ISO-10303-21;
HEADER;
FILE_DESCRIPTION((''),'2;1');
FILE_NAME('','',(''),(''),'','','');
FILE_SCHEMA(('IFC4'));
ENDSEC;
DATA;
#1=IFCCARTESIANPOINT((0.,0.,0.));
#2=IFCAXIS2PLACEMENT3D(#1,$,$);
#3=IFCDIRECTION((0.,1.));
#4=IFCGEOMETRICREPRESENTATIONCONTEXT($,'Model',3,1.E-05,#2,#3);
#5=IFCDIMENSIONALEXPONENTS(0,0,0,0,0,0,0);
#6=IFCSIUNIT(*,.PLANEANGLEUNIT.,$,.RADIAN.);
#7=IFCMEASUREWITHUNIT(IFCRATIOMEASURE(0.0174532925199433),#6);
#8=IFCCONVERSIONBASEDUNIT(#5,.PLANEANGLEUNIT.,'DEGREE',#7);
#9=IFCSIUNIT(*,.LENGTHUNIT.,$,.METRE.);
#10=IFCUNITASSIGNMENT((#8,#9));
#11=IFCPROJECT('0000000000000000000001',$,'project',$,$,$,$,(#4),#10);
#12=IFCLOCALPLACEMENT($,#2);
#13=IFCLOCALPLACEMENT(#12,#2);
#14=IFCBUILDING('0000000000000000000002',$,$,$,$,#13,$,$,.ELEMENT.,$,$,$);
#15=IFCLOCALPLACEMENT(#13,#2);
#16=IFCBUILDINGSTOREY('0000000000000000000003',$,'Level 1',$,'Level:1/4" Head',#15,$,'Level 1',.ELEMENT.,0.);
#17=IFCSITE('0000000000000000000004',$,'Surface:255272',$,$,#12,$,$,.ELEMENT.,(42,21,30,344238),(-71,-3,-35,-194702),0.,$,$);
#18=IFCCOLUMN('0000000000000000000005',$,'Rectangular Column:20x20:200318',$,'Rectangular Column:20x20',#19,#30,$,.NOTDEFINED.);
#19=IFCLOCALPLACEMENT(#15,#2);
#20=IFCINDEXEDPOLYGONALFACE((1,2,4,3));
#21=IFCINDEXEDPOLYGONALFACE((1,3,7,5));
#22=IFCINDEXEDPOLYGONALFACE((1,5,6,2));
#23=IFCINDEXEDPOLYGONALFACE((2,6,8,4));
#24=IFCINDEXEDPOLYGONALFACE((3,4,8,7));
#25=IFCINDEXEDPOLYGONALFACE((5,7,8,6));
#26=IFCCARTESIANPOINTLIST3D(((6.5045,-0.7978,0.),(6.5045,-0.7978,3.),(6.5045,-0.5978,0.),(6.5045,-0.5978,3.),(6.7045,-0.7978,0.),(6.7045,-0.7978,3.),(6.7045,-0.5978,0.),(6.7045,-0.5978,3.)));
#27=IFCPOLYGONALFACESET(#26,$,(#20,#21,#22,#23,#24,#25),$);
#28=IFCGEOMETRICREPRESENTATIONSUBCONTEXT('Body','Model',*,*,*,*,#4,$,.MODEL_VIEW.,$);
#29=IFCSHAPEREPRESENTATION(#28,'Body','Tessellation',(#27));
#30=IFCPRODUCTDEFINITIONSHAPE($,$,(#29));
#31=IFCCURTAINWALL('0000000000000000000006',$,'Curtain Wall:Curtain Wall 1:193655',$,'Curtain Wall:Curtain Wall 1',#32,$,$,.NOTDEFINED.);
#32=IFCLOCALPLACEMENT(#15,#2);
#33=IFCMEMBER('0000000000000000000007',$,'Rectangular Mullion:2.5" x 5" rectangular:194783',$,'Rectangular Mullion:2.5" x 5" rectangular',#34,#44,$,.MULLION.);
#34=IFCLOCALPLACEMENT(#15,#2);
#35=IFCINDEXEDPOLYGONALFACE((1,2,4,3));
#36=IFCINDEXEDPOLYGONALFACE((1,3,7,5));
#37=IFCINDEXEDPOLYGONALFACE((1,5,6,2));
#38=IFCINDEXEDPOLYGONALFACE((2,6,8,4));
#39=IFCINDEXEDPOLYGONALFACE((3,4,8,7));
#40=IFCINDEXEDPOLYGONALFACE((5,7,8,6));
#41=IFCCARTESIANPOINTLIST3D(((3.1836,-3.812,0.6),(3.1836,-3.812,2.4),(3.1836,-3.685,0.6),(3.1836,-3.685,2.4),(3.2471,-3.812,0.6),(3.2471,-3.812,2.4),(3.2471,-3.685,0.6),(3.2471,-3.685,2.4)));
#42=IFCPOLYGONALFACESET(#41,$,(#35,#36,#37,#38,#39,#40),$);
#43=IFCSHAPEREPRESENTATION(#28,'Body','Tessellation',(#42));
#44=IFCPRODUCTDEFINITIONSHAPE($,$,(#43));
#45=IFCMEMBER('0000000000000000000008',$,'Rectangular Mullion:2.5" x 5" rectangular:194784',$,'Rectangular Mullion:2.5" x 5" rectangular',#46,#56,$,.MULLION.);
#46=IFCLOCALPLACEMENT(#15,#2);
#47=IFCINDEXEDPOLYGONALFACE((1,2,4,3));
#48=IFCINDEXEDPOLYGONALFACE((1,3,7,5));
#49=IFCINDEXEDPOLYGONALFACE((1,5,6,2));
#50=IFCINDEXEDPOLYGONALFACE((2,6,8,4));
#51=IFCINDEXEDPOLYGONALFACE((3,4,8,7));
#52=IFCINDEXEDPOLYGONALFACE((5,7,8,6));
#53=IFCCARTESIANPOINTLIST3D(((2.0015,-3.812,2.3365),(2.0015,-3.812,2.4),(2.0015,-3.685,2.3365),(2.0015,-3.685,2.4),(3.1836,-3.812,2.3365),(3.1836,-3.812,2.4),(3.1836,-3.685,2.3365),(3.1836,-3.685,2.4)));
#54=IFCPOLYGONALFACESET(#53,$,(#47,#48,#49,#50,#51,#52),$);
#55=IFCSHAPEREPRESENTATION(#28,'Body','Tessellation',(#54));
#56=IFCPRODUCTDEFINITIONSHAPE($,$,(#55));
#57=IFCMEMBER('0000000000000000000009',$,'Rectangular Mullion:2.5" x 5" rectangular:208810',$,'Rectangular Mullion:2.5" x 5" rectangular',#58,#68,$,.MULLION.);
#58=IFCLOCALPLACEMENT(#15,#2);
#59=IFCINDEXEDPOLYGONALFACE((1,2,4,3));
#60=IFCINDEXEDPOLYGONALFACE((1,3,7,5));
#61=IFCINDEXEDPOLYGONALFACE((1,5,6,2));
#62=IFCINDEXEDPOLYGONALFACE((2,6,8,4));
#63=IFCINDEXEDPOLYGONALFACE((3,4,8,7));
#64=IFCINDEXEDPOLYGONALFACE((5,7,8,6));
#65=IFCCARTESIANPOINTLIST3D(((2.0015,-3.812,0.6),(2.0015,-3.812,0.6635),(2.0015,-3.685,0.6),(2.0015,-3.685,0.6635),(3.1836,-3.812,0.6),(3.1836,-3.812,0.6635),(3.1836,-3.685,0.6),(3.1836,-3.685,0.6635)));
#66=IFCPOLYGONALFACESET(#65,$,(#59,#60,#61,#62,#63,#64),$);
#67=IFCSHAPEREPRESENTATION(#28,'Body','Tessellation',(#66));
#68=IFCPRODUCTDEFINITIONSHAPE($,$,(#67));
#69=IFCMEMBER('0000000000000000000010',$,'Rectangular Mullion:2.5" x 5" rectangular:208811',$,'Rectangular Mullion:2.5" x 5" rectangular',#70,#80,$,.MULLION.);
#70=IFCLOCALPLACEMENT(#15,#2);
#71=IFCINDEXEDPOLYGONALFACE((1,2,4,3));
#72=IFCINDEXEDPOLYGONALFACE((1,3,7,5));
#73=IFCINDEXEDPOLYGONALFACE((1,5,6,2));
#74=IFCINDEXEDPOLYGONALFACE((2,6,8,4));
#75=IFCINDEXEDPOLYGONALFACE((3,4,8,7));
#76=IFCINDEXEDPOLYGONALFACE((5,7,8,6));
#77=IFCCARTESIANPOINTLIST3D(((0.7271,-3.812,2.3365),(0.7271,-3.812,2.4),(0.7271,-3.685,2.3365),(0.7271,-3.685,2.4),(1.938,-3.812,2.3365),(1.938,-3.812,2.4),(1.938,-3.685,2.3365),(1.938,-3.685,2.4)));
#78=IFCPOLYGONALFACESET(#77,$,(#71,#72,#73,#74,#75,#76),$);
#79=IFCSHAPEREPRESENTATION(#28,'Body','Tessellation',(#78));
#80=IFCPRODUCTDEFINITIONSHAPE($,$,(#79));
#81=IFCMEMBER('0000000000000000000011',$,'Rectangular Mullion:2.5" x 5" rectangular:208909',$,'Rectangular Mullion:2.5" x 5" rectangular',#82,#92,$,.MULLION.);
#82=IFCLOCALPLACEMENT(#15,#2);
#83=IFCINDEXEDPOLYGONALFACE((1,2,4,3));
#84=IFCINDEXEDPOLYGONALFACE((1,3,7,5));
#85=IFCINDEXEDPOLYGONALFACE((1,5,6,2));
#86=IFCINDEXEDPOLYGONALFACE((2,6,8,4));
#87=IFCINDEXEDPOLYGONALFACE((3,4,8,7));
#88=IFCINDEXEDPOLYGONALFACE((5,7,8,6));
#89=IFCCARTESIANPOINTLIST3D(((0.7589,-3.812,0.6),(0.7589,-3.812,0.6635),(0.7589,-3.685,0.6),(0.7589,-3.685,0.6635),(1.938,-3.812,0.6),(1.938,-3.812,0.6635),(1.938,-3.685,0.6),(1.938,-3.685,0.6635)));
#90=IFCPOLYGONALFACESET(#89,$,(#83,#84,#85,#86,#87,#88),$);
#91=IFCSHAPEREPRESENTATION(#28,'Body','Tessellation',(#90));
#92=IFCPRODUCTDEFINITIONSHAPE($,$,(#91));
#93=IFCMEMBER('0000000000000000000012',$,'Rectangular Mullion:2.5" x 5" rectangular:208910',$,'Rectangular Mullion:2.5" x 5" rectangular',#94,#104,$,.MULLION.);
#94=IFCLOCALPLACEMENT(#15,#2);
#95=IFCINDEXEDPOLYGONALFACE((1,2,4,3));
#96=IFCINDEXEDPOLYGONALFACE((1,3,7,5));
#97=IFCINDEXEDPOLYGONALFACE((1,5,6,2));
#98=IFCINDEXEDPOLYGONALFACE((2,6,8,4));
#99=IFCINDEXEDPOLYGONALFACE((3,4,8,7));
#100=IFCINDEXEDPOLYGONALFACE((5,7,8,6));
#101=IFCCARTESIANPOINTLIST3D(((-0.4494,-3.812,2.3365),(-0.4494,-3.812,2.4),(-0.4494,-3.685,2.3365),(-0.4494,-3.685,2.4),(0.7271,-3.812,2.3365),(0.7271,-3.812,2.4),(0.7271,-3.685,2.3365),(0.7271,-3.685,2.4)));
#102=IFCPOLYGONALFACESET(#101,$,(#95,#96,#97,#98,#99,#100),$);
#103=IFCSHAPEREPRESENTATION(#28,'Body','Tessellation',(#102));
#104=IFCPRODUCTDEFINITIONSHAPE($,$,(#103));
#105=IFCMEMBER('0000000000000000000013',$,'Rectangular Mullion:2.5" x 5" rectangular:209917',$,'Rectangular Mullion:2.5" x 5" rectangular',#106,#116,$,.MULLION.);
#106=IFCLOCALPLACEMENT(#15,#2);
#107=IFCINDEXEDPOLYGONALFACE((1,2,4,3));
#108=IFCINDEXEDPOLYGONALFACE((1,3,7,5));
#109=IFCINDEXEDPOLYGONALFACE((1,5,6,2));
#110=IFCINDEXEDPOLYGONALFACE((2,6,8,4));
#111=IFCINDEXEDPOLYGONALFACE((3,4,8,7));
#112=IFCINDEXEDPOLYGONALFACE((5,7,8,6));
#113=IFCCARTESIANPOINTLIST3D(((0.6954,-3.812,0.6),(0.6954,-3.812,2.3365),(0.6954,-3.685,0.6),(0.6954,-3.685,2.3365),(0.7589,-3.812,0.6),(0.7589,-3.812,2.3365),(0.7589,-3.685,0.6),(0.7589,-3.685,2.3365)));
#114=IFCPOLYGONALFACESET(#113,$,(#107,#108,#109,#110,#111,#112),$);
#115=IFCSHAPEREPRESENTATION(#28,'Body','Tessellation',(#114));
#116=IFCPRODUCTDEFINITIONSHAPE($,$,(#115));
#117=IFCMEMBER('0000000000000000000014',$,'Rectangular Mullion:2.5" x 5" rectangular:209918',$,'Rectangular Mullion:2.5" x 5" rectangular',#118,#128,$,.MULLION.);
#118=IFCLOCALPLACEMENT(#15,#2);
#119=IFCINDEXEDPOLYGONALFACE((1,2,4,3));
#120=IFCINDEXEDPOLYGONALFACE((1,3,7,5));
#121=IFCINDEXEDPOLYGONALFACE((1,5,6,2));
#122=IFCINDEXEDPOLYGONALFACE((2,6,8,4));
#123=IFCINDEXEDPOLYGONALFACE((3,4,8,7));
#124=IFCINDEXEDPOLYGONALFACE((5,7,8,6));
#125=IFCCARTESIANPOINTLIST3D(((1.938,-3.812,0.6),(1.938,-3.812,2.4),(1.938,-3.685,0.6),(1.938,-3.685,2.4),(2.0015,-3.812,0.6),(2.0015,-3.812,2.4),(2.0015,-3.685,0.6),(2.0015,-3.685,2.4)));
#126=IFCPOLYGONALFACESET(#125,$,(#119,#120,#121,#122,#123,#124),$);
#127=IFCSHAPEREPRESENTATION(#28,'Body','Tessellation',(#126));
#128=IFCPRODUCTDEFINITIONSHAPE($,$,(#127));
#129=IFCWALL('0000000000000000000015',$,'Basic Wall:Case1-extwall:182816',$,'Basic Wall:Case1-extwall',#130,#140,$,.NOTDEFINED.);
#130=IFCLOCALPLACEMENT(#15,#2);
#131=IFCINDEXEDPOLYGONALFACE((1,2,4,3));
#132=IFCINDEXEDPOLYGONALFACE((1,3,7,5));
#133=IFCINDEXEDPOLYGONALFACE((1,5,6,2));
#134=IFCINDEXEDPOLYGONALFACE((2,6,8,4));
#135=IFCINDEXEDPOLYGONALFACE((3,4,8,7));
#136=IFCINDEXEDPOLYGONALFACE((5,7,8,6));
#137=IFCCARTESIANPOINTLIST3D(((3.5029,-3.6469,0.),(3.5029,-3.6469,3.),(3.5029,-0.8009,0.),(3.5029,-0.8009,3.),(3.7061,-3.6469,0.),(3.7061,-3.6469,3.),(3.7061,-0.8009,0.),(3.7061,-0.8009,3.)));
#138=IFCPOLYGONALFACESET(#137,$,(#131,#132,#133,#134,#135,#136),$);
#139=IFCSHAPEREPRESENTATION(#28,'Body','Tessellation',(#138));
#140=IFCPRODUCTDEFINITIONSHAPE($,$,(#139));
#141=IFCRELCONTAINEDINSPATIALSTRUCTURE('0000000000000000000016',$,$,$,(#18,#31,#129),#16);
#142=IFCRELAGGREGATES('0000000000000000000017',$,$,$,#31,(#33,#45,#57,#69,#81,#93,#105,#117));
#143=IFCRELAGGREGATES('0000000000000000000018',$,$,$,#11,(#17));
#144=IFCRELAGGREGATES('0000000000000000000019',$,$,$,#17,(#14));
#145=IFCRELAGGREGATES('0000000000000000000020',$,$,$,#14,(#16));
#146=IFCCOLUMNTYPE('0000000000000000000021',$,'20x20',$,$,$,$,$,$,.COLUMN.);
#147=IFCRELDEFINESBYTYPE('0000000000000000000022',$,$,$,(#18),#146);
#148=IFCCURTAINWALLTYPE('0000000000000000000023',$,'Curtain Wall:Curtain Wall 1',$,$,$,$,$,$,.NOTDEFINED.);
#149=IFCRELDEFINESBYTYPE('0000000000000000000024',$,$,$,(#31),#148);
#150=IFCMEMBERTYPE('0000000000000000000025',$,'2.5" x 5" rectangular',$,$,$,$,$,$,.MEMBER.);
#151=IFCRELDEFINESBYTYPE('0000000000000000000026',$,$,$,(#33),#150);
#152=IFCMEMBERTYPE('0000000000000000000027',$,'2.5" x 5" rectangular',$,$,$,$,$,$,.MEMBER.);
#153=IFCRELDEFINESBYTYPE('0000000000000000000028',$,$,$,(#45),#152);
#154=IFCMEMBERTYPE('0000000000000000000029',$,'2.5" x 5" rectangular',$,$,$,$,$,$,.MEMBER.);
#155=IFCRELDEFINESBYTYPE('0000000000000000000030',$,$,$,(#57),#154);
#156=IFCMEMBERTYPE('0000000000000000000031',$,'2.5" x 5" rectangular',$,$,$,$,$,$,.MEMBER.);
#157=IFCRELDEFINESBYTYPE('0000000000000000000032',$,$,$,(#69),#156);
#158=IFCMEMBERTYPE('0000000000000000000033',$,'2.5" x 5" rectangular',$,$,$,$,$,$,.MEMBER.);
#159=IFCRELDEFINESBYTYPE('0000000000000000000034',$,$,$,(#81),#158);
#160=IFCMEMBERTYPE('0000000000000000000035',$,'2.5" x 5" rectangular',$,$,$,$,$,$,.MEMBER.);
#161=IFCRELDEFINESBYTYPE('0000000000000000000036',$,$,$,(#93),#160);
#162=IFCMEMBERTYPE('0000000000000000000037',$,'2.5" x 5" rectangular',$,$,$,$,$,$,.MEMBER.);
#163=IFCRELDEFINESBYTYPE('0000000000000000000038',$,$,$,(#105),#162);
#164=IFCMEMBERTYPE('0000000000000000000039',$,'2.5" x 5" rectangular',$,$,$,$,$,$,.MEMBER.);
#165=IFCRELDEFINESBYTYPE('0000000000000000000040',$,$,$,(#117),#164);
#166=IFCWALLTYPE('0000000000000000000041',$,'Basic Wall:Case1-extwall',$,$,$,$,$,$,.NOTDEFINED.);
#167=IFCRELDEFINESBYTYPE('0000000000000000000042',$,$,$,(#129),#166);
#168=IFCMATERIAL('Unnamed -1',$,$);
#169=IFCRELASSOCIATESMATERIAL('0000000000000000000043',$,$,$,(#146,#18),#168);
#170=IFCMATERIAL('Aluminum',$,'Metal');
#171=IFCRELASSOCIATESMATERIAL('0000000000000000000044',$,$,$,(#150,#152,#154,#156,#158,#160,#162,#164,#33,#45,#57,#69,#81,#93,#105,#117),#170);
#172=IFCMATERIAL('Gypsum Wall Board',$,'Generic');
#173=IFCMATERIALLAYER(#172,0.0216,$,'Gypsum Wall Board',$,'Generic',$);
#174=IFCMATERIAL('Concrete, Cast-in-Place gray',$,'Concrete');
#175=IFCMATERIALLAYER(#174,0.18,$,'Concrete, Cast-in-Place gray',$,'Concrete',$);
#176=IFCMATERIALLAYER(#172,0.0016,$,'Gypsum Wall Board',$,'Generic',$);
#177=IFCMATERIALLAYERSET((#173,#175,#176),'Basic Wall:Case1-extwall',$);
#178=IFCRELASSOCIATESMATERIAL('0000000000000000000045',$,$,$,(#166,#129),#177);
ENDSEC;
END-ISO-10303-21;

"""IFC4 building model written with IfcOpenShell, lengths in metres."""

from ifc_helpers import new_model, entity, si_unit, converted_unit, direction, frame, frame_2d, origin, origin_2d_with_axis, place, context, subcontext, project, spatial, polyline, rectangle, extrude, clip, bounded_halfspace, source, transform, mapped, material, layer, layer_set, layer_usage, material_profile, profile_set, profile_usage, type_object, type_shapes, element, aggregate, save


model = new_model("IFC4")

# Units and contexts
model_context = context("Model", 3, precision=1e-05, world=origin(), true_north=direction((0.0, 1.0)))
body_context = subcontext(model_context, "Body", "Model", "MODEL_VIEW")
ifc_project = project(units=[converted_unit("PLANEANGLEUNIT", "DEGREE", entity("IfcRatioMeasure", 0.0174532925199433), si_unit("PLANEANGLEUNIT", "RADIAN"), dimensions=[0, 0, 0, 0, 0, 0, 0]), si_unit("LENGTHUNIT", "METRE")], contexts=[model_context])

# Site, building, storey
site_placement = place(None, origin())
site = spatial("IfcSite", under=ifc_project, at=site_placement, Name="Surface:255272", CompositionType="ELEMENT", RefLatitude=(42, 21, 30, 344238), RefLongitude=(-71, -3, -35, -194702), RefElevation=0.0)
building_placement = place(site_placement, origin())
building = spatial("IfcBuilding", under=site, at=building_placement, CompositionType="ELEMENT")
storey_placement = place(building_placement, origin())
storey = spatial("IfcBuildingStorey", under=building, at=storey_placement, Name="Level 1", ObjectType="Level:1/4\" Head", LongName="Level 1", CompositionType="ELEMENT", Elevation=0.0)

# Column
ifc_material_1 = material(Name="Unnamed -1")
ifc_material_profile_1 = material_profile(ifc_material_1, rectangle(XDim=0.2, YDim=0.2, at=origin_2d_with_axis()), Name="20x20")
ifc_profile_set_1 = profile_set([ifc_material_profile_1], Name="20x20")
ifc_profile_usage_1 = profile_usage(ifc_profile_set_1)
column_type = type_object("IfcColumnType", Name="20x20", PredefinedType="COLUMN", material=ifc_profile_set_1)
shared_shape_1 = source(origin(), body_context, "Body", "SweptSolid", [
    extrude(rectangle(XDim=0.2, YDim=0.2, at=origin_2d_with_axis()), frame((0.0, 0.0, 0.0), z_axis=(0.0, 0.0, 1.0), x_axis=(0.0, -1.0, 0.0)), (0.0, 0.0, 1.0), 3.0),
])
type_shapes(column_type, [shared_shape_1])
column_placement = place(storey_placement, frame((6.6045, -0.6978, 0.0)))
element("IfcColumn", 1, at=column_placement, inside=storey, type_object=column_type, material=ifc_profile_usage_1, Name="Rectangular Column:20x20:200318", ObjectType="Rectangular Column:20x20", PredefinedType="NOTDEFINED", context=body_context, shape_type="MappedRepresentation", body=[
    mapped(shared_shape_1, transform((0.0, 0.0, 0.0), scale=1.0)),
])

# Curtain wall, member
curtain_wall_type = type_object("IfcCurtainWallType", Name="Curtain Wall:Curtain Wall 1", PredefinedType="NOTDEFINED")
ifc_material_2 = material(Name="Aluminum", Category="Metal")
ifc_material_profile_2 = material_profile(ifc_material_2, rectangle(XDim=0.127, YDim=0.0635, at=origin_2d_with_axis()), Name="2.5\" x 5\" rectangular")
ifc_profile_set_2 = profile_set([ifc_material_profile_2], Name="2.5\" x 5\" rectangular")
curtain_wall_1_placement = place(storey_placement, origin())
curtain_wall_1 = element("IfcCurtainWall", 2, at=curtain_wall_1_placement, inside=storey, type_object=curtain_wall_type, Name="Curtain Wall:Curtain Wall 1:193655", ObjectType="Curtain Wall:Curtain Wall 1", PredefinedType="NOTDEFINED")
ifc_profile_usage_2 = profile_usage(ifc_profile_set_2)
member_type_1 = type_object("IfcMemberType", Name="2.5\" x 5\" rectangular", PredefinedType="MEMBER", material=ifc_profile_set_2)
shared_shape_2 = source(origin(), body_context, "Body", "SweptSolid", [
    extrude(rectangle(XDim=0.127, YDim=0.0635, at=origin_2d_with_axis()), frame((-0.0318, 0.0, -1.8), z_axis=(0.0, 0.0, 1.0), x_axis=(0.0, -1.0, 0.0)), (0.0, 0.0, 1.0), 1.8),
])
type_shapes(member_type_1, [shared_shape_2])
member_1_placement = place(storey_placement, frame((3.2471, -3.7485, 0.6), z_axis=(0.0, 0.0, -1.0), x_axis=(1.0, -0.000007, 0.0)))
member_1 = element("IfcMember", 3, at=member_1_placement, type_object=member_type_1, material=ifc_profile_usage_2, Name="Rectangular Mullion:2.5\" x 5\" rectangular:194783", ObjectType="Rectangular Mullion:2.5\" x 5\" rectangular", PredefinedType="MULLION", context=body_context, shape_type="MappedRepresentation", body=[
    mapped(shared_shape_2, transform((0.0, 0.0, 0.0), scale=1.0)),
])

# Members
ifc_profile_usage_3 = profile_usage(ifc_profile_set_2)
member_type_2 = type_object("IfcMemberType", Name="2.5\" x 5\" rectangular", PredefinedType="MEMBER", material=ifc_profile_set_2)
shared_shape_3 = source(origin(), body_context, "Body", "SweptSolid", [
    extrude(rectangle(XDim=0.127, YDim=0.0635, at=origin_2d_with_axis()), frame((-0.0318, 0.0, -1.1821), z_axis=(0.0, 0.0, 1.0), x_axis=(0.0, -1.0, 0.0)), (0.0, 0.0, 1.0), 1.1821),
])
type_shapes(member_type_2, [shared_shape_3])
member_2_placement = place(storey_placement, frame((3.1836, -3.7485, 2.4), z_axis=(1.0, -0.000007, 0.0), x_axis=(0.0, 0.0, 1.0)))
member_2 = element("IfcMember", 4, at=member_2_placement, type_object=member_type_2, material=ifc_profile_usage_3, Name="Rectangular Mullion:2.5\" x 5\" rectangular:194784", ObjectType="Rectangular Mullion:2.5\" x 5\" rectangular", PredefinedType="MULLION", context=body_context, shape_type="MappedRepresentation", body=[
    mapped(shared_shape_3, transform((0.0, 0.0, 0.0), scale=1.0)),
])
ifc_profile_usage_4 = profile_usage(ifc_profile_set_2)
member_type_3 = type_object("IfcMemberType", Name="2.5\" x 5\" rectangular", PredefinedType="MEMBER", material=ifc_profile_set_2)
shared_shape_4 = source(origin(), body_context, "Body", "SweptSolid", [
    extrude(rectangle(XDim=0.127, YDim=0.0635, at=origin_2d_with_axis()), frame((-0.0318, 0.0, -1.1821), z_axis=(0.0, 0.0, 1.0), x_axis=(0.0, -1.0, 0.0)), (0.0, 0.0, 1.0), 1.1821),
])
type_shapes(member_type_3, [shared_shape_4])
member_3_placement = place(storey_placement, frame((2.0015, -3.7485, 0.6), z_axis=(-1.0, 0.000007, 0.0), x_axis=(0.0, 0.0, -1.0)))
member_3 = element("IfcMember", 5, at=member_3_placement, type_object=member_type_3, material=ifc_profile_usage_4, Name="Rectangular Mullion:2.5\" x 5\" rectangular:208810", ObjectType="Rectangular Mullion:2.5\" x 5\" rectangular", PredefinedType="MULLION", context=body_context, shape_type="MappedRepresentation", body=[
    mapped(shared_shape_4, transform((0.0, 0.0, 0.0), scale=1.0)),
])
ifc_profile_usage_5 = profile_usage(ifc_profile_set_2)
member_type_4 = type_object("IfcMemberType", Name="2.5\" x 5\" rectangular", PredefinedType="MEMBER", material=ifc_profile_set_2)
shared_shape_5 = source(origin(), body_context, "Body", "SweptSolid", [
    extrude(rectangle(XDim=0.127, YDim=0.0635, at=origin_2d_with_axis()), frame((-0.0318, 0.0, -1.2109), z_axis=(0.0, 0.0, 1.0), x_axis=(0.0, -1.0, 0.0)), (0.0, 0.0, 1.0), 1.2109),
])
type_shapes(member_type_4, [shared_shape_5])
member_4_placement = place(storey_placement, frame((1.938, -3.7485, 2.4), z_axis=(1.0, -0.000007, 0.0), x_axis=(0.0, 0.0, 1.0)))
member_4 = element("IfcMember", 6, at=member_4_placement, type_object=member_type_4, material=ifc_profile_usage_5, Name="Rectangular Mullion:2.5\" x 5\" rectangular:208811", ObjectType="Rectangular Mullion:2.5\" x 5\" rectangular", PredefinedType="MULLION", context=body_context, shape_type="MappedRepresentation", body=[
    mapped(shared_shape_5, transform((0.0, 0.0, 0.0), scale=1.0)),
])
ifc_profile_usage_6 = profile_usage(ifc_profile_set_2)
member_type_5 = type_object("IfcMemberType", Name="2.5\" x 5\" rectangular", PredefinedType="MEMBER", material=ifc_profile_set_2)
shared_shape_6 = source(origin(), body_context, "Body", "SweptSolid", [
    extrude(rectangle(XDim=0.127, YDim=0.0635, at=origin_2d_with_axis()), frame((-0.0318, 0.0, -1.1792), z_axis=(0.0, 0.0, 1.0), x_axis=(0.0, -1.0, 0.0)), (0.0, 0.0, 1.0), 1.1792),
])
type_shapes(member_type_5, [shared_shape_6])
member_5_placement = place(storey_placement, frame((0.7589, -3.7485, 0.6), z_axis=(-1.0, 0.000007, 0.0), x_axis=(0.0, 0.0, -1.0)))
member_5 = element("IfcMember", 7, at=member_5_placement, type_object=member_type_5, material=ifc_profile_usage_6, Name="Rectangular Mullion:2.5\" x 5\" rectangular:208909", ObjectType="Rectangular Mullion:2.5\" x 5\" rectangular", PredefinedType="MULLION", context=body_context, shape_type="MappedRepresentation", body=[
    mapped(shared_shape_6, transform((0.0, 0.0, 0.0), scale=1.0)),
])
ifc_profile_usage_7 = profile_usage(ifc_profile_set_2)
member_type_6 = type_object("IfcMemberType", Name="2.5\" x 5\" rectangular", PredefinedType="MEMBER", material=ifc_profile_set_2)
shared_shape_7 = source(origin(), body_context, "Body", "SweptSolid", [
    extrude(rectangle(XDim=0.127, YDim=0.0635, at=origin_2d_with_axis()), frame((-0.0318, 0.0, -1.1765), z_axis=(0.0, 0.0, 1.0), x_axis=(0.0, -1.0, 0.0)), (0.0, 0.0, 1.0), 1.1765),
])
type_shapes(member_type_6, [shared_shape_7])
member_6_placement = place(storey_placement, frame((0.7271, -3.7485, 2.4), z_axis=(1.0, -0.000007, 0.0), x_axis=(0.0, 0.0, 1.0)))
member_6 = element("IfcMember", 8, at=member_6_placement, type_object=member_type_6, material=ifc_profile_usage_7, Name="Rectangular Mullion:2.5\" x 5\" rectangular:208910", ObjectType="Rectangular Mullion:2.5\" x 5\" rectangular", PredefinedType="MULLION", context=body_context, shape_type="MappedRepresentation", body=[
    mapped(shared_shape_7, transform((0.0, 0.0, 0.0), scale=1.0)),
])
ifc_profile_usage_8 = profile_usage(ifc_profile_set_2)
member_type_7 = type_object("IfcMemberType", Name="2.5\" x 5\" rectangular", PredefinedType="MEMBER", material=ifc_profile_set_2)
shared_shape_8 = source(origin(), body_context, "Body", "SweptSolid", [
    extrude(rectangle(XDim=0.127, YDim=0.0635, at=origin_2d_with_axis()), frame((0.0, 0.0, -1.7365), z_axis=(0.0, 0.0, 1.0), x_axis=(0.0, -1.0, 0.0)), (0.0, 0.0, 1.0), 1.7365),
])
type_shapes(member_type_7, [shared_shape_8])
member_7_placement = place(storey_placement, frame((0.7271, -3.7485, 0.6), z_axis=(0.0, 0.0, -1.0), x_axis=(1.0, -0.000007, 0.0)))
member_7 = element("IfcMember", 9, at=member_7_placement, type_object=member_type_7, material=ifc_profile_usage_8, Name="Rectangular Mullion:2.5\" x 5\" rectangular:209917", ObjectType="Rectangular Mullion:2.5\" x 5\" rectangular", PredefinedType="MULLION", context=body_context, shape_type="MappedRepresentation", body=[
    mapped(shared_shape_8, transform((0.0, 0.0, 0.0), scale=1.0)),
])
ifc_profile_usage_9 = profile_usage(ifc_profile_set_2)
member_type_8 = type_object("IfcMemberType", Name="2.5\" x 5\" rectangular", PredefinedType="MEMBER", material=ifc_profile_set_2)
shared_shape_9 = source(origin(), body_context, "Body", "SweptSolid", [
    extrude(rectangle(XDim=0.127, YDim=0.0635, at=origin_2d_with_axis()), frame((0.0, 0.0, -1.8), z_axis=(0.0, 0.0, 1.0), x_axis=(0.0, -1.0, 0.0)), (0.0, 0.0, 1.0), 1.8),
])
type_shapes(member_type_8, [shared_shape_9])
member_8_placement = place(storey_placement, frame((1.9698, -3.7485, 0.6), z_axis=(0.0, 0.0, -1.0), x_axis=(1.0, -0.000007, 0.0)))
member_8 = element("IfcMember", 10, at=member_8_placement, type_object=member_type_8, material=ifc_profile_usage_9, Name="Rectangular Mullion:2.5\" x 5\" rectangular:209918", ObjectType="Rectangular Mullion:2.5\" x 5\" rectangular", PredefinedType="MULLION", context=body_context, shape_type="MappedRepresentation", body=[
    mapped(shared_shape_9, transform((0.0, 0.0, 0.0), scale=1.0)),
])

aggregate(curtain_wall_1, [member_1, member_2, member_3, member_4, member_5, member_6, member_7, member_8])

# Wall
ifc_material_3 = material(Name="Gypsum Wall Board", Category="Generic")
ifc_layer_1 = layer(ifc_material_3, 0.0216, Name="Gypsum Wall Board", Category="Generic")
ifc_material_4 = material(Name="Concrete, Cast-in-Place gray", Category="Concrete")
ifc_layer_2 = layer(ifc_material_4, 0.18, Name="Concrete, Cast-in-Place gray", Category="Concrete")
ifc_layer_3 = layer(ifc_material_3, 0.0016, Name="Gypsum Wall Board", Category="Generic")
ifc_layer_set_1 = layer_set([ifc_layer_1, ifc_layer_2, ifc_layer_3], Name="Basic Wall:Case1-extwall")
ifc_layer_usage_1 = layer_usage(ifc_layer_set_1, "AXIS2", "NEGATIVE", 0.1016)
wall_type = type_object("IfcWallType", Name="Basic Wall:Case1-extwall", PredefinedType="NOTDEFINED", material=ifc_layer_set_1)
wall_1_placement = place(storey_placement, frame((3.6045, -3.6469, 0.0), z_axis=(0.0, 0.0, 1.0), x_axis=(0.000007, 1.0, 0.0)))
element("IfcWall", 11, at=wall_1_placement, inside=storey, type_object=wall_type, material=ifc_layer_usage_1, Name="Basic Wall:Case1-extwall:182816", ObjectType="Basic Wall:Case1-extwall", PredefinedType="NOTDEFINED", context=body_context, shape_type="Clipping", body=[
    clip(extrude(rectangle(XDim=2.846, YDim=0.2032, at=frame_2d((1.423, 0.0), x_axis=(-1.0, 0.0))), origin(), (0.0, 0.0, 1.0), 3.0), bounded_halfspace(frame((0.0, -0.1016, 3.0), z_axis=(0.0, 0.0, -1.0), x_axis=(0.0, 1.0, 0.0)), True, frame((0.0, -0.1016, 3.0)), polyline([(0.0, 0.0), (2.846, 0.0), (2.846, 0.2032), (2.673, 0.2032), (2.5206, 0.2032), (0.0, 0.2032), (0.0, 0.0)]))),
])

save(model, "model.ifc")
